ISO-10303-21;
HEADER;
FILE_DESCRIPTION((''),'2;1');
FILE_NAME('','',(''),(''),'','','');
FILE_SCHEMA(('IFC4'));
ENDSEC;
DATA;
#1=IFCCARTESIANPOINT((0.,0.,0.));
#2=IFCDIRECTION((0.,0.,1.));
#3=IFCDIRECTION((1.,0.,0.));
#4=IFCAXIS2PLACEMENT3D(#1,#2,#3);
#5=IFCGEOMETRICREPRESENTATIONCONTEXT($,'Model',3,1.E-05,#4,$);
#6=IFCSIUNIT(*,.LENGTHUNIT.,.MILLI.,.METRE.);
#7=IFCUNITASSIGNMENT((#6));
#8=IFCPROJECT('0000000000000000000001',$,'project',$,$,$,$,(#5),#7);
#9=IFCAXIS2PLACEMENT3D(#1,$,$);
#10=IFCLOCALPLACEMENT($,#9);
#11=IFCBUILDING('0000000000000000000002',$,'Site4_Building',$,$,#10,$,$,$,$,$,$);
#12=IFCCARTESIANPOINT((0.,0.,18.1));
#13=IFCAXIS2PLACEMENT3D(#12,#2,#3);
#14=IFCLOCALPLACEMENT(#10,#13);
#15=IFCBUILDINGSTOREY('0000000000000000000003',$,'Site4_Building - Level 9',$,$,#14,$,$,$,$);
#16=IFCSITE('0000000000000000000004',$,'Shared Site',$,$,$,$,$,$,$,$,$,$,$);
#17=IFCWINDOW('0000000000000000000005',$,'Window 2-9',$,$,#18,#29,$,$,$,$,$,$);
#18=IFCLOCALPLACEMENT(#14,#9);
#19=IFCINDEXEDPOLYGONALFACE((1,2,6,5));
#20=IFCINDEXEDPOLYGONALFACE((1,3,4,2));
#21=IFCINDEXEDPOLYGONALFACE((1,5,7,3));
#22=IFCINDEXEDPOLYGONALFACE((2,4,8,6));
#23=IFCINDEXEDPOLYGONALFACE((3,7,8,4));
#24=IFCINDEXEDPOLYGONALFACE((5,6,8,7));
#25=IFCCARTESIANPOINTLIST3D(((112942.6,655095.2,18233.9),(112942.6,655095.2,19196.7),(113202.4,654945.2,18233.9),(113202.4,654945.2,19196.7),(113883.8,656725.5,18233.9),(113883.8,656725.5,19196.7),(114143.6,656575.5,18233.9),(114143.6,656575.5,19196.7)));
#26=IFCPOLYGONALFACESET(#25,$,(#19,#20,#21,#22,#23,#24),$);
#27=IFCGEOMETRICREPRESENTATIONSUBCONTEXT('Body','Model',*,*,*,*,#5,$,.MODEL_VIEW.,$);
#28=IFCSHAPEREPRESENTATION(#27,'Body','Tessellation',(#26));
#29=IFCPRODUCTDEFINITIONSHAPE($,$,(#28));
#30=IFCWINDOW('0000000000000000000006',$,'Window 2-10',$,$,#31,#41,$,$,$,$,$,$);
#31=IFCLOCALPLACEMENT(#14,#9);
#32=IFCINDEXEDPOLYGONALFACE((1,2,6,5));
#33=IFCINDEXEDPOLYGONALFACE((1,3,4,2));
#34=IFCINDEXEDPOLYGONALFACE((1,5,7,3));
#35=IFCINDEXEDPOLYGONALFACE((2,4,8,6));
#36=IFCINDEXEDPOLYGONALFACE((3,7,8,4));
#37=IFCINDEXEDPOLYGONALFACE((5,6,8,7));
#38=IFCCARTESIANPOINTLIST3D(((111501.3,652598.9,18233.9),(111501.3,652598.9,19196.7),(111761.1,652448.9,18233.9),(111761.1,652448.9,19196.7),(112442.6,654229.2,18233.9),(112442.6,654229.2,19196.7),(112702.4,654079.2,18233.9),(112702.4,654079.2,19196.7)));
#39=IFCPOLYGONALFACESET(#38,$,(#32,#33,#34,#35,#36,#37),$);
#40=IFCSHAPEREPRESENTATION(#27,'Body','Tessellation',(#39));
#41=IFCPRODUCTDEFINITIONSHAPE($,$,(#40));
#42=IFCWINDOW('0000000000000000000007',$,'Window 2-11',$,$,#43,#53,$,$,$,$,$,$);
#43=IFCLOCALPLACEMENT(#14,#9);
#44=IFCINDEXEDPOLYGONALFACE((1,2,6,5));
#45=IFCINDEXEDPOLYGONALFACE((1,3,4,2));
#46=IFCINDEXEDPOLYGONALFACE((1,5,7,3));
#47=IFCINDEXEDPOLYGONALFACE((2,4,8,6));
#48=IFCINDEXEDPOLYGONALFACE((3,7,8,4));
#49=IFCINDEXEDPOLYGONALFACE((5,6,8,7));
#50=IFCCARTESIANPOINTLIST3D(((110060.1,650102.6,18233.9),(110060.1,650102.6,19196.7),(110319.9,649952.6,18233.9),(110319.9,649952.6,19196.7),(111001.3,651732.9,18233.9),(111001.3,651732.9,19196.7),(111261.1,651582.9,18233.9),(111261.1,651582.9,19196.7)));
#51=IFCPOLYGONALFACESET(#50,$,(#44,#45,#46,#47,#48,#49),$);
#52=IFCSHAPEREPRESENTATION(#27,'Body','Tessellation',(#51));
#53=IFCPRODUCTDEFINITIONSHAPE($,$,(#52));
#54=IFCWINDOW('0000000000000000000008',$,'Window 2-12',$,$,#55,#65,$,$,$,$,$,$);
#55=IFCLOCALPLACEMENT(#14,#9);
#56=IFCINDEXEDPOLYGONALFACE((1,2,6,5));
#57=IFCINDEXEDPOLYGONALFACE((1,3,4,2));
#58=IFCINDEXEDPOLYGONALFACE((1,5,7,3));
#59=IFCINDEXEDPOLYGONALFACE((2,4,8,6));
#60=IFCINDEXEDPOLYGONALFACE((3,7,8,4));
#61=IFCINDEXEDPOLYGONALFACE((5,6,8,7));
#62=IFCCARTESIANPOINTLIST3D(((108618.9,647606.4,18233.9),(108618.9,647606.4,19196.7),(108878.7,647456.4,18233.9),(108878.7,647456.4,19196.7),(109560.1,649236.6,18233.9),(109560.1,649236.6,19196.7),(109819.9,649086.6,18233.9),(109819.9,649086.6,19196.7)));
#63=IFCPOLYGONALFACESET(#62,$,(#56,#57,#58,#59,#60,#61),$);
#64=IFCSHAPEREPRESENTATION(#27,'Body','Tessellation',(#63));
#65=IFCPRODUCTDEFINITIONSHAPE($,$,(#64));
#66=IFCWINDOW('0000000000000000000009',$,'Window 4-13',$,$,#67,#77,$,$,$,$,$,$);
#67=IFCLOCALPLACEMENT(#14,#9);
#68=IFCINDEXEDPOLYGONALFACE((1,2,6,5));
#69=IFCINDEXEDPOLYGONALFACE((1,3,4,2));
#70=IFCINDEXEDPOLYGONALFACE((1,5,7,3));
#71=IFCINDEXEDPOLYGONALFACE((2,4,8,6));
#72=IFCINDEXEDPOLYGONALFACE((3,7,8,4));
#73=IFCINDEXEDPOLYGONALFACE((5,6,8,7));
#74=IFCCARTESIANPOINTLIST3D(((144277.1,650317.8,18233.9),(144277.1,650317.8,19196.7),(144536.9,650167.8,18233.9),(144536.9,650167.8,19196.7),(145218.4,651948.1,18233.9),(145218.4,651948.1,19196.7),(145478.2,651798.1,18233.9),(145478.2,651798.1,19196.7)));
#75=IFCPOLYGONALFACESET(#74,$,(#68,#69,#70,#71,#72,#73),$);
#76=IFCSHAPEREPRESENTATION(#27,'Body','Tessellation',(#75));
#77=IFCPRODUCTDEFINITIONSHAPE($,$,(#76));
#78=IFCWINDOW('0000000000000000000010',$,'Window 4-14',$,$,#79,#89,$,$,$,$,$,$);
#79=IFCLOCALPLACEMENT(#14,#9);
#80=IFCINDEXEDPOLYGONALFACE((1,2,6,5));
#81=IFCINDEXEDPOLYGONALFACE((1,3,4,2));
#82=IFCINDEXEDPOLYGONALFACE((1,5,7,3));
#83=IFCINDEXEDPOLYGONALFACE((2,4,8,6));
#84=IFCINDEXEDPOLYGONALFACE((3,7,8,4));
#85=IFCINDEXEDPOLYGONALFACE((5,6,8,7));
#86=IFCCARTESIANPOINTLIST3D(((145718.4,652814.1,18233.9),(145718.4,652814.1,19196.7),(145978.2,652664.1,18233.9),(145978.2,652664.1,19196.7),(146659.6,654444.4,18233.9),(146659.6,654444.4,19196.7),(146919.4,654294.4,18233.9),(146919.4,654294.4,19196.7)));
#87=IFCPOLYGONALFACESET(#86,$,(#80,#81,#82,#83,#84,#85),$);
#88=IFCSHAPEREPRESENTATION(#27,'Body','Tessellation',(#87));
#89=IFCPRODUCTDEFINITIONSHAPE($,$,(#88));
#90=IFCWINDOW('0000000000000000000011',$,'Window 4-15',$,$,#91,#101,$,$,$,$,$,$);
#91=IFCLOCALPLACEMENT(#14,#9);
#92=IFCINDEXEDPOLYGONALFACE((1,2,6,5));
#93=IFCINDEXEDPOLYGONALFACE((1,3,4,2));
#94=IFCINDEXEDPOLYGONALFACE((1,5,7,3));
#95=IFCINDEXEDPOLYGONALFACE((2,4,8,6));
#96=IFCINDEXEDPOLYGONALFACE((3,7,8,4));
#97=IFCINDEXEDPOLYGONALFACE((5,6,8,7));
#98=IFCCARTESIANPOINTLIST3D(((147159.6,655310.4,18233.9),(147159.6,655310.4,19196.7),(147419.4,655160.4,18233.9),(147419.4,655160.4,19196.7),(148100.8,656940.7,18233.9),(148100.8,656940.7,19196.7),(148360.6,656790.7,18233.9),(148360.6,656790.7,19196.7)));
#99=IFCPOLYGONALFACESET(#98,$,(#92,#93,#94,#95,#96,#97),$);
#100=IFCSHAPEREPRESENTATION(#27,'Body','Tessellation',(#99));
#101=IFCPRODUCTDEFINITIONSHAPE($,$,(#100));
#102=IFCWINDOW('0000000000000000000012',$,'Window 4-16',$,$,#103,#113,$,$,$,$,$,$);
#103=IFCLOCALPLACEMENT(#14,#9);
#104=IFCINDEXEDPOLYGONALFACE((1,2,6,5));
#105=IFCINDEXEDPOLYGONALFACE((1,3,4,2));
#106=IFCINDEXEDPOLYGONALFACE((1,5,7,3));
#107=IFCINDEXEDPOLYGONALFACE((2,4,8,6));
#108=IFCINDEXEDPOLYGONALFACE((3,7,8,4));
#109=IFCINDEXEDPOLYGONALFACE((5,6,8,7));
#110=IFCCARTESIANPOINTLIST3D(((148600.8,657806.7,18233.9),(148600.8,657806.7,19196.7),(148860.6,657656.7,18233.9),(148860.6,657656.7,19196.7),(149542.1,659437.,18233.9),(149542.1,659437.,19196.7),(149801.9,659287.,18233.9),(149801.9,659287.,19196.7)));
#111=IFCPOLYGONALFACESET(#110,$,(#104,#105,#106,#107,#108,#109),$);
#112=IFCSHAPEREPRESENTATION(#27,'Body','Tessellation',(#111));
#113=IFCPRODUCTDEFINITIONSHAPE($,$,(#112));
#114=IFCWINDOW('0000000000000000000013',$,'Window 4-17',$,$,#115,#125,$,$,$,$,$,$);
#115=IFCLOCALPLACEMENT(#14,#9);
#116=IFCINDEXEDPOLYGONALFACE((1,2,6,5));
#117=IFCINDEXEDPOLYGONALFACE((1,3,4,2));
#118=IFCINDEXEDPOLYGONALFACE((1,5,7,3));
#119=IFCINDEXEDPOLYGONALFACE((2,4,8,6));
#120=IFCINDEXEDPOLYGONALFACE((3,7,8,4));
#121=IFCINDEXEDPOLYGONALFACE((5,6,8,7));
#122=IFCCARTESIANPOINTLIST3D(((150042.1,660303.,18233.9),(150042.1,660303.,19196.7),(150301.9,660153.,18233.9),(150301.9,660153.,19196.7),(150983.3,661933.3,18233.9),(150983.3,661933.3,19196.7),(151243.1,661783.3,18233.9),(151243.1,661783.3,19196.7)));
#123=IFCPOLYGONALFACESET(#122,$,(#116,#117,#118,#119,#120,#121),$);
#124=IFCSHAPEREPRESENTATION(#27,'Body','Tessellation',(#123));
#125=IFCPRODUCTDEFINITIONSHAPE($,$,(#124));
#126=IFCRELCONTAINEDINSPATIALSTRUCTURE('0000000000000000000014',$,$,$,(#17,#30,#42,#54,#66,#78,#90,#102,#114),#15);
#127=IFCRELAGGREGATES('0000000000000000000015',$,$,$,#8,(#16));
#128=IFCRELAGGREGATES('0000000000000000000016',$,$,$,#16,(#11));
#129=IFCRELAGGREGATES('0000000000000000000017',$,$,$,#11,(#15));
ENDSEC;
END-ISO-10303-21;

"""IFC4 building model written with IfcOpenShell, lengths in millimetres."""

from ifc_helpers import new_model, si_unit, frame, origin, origin_with_axes, place, context, subcontext, project, spatial, indexed_curve, outline, extrude, element, save


model = new_model("IFC4")

# Units and contexts
model_context = context("Model", 3, precision=1e-05, world=origin_with_axes())
body_context = subcontext(model_context, "Body", "Model", "MODEL_VIEW")
ifc_project = project(units=[si_unit("LENGTHUNIT", "METRE", prefix="MILLI")], contexts=[model_context])

# Site, building, storey
site = spatial("IfcSite", under=ifc_project, Name="Shared Site")
building_placement = place(None, origin())
building = spatial("IfcBuilding", under=site, at=building_placement, Name="Site4_Building")
storey_placement = place(building_placement, frame((0.0, 0.0, 18.1), z_axis=(0.0, 0.0, 1.0), x_axis=(1.0, 0.0, 0.0)))
storey = spatial("IfcBuildingStorey", under=building, at=storey_placement, Name="Site4_Building - Level 9")

# Windows
for number, where, z_axis, x_axis, name in (
    (1, (113883.8, 656725.5, 18233.9), (0.0, 0.0, 1.0), (-0.5, -0.866025, 0.0), "Window 2-9"),
    (2, (112442.6, 654229.2, 18233.9), (0.0, 0.0, 1.0), (-0.5, -0.866025, 0.0), "Window 2-10"),
    (3, (111001.3, 651732.9, 18233.9), (0.0, 0.0, 1.0), (-0.5, -0.866025, 0.0), "Window 2-11"),
    (4, (109560.1, 649236.6, 18233.9), (0.0, 0.0, 1.0), (-0.5, -0.866025, 0.0), "Window 2-12"),
    (5, (144536.9, 650167.8, 18233.9), (0.0, 0.0, 1.0), (0.5, 0.866025, 0.0), "Window 4-13"),
    (6, (145978.2, 652664.1, 18233.9), (0.0, 0.0, 1.0), (0.5, 0.866025, 0.0), "Window 4-14"),
    (7, (147419.4, 655160.4, 18233.9), (0.0, 0.0, 1.0), (0.5, 0.866025, 0.0), "Window 4-15"),
    (8, (148860.6, 657656.7, 18233.9), (0.0, 0.0, 1.0), (0.5, 0.866025, 0.0), "Window 4-16"),
    (9, (150301.9, 660153.0, 18233.9), (0.0, 0.0, 1.0), (0.5, 0.866025, 0.0), "Window 4-17"),
):
    element("IfcWindow", number, at=place(storey_placement, frame(where, z_axis=z_axis, x_axis=x_axis)), inside=storey, Name=name, context=body_context, shape_type="SweptSolid", body=[
        extrude(outline(indexed_curve([(0.0, 0.0), (0.0, 300.0), (1882.5, 300.0), (1882.5, 0.0), (0.0, 0.0)], self_intersect=False)), origin_with_axes(), (0.0, 0.0, 1.0), 962.8),
    ])

save(model, "model.ifc")
